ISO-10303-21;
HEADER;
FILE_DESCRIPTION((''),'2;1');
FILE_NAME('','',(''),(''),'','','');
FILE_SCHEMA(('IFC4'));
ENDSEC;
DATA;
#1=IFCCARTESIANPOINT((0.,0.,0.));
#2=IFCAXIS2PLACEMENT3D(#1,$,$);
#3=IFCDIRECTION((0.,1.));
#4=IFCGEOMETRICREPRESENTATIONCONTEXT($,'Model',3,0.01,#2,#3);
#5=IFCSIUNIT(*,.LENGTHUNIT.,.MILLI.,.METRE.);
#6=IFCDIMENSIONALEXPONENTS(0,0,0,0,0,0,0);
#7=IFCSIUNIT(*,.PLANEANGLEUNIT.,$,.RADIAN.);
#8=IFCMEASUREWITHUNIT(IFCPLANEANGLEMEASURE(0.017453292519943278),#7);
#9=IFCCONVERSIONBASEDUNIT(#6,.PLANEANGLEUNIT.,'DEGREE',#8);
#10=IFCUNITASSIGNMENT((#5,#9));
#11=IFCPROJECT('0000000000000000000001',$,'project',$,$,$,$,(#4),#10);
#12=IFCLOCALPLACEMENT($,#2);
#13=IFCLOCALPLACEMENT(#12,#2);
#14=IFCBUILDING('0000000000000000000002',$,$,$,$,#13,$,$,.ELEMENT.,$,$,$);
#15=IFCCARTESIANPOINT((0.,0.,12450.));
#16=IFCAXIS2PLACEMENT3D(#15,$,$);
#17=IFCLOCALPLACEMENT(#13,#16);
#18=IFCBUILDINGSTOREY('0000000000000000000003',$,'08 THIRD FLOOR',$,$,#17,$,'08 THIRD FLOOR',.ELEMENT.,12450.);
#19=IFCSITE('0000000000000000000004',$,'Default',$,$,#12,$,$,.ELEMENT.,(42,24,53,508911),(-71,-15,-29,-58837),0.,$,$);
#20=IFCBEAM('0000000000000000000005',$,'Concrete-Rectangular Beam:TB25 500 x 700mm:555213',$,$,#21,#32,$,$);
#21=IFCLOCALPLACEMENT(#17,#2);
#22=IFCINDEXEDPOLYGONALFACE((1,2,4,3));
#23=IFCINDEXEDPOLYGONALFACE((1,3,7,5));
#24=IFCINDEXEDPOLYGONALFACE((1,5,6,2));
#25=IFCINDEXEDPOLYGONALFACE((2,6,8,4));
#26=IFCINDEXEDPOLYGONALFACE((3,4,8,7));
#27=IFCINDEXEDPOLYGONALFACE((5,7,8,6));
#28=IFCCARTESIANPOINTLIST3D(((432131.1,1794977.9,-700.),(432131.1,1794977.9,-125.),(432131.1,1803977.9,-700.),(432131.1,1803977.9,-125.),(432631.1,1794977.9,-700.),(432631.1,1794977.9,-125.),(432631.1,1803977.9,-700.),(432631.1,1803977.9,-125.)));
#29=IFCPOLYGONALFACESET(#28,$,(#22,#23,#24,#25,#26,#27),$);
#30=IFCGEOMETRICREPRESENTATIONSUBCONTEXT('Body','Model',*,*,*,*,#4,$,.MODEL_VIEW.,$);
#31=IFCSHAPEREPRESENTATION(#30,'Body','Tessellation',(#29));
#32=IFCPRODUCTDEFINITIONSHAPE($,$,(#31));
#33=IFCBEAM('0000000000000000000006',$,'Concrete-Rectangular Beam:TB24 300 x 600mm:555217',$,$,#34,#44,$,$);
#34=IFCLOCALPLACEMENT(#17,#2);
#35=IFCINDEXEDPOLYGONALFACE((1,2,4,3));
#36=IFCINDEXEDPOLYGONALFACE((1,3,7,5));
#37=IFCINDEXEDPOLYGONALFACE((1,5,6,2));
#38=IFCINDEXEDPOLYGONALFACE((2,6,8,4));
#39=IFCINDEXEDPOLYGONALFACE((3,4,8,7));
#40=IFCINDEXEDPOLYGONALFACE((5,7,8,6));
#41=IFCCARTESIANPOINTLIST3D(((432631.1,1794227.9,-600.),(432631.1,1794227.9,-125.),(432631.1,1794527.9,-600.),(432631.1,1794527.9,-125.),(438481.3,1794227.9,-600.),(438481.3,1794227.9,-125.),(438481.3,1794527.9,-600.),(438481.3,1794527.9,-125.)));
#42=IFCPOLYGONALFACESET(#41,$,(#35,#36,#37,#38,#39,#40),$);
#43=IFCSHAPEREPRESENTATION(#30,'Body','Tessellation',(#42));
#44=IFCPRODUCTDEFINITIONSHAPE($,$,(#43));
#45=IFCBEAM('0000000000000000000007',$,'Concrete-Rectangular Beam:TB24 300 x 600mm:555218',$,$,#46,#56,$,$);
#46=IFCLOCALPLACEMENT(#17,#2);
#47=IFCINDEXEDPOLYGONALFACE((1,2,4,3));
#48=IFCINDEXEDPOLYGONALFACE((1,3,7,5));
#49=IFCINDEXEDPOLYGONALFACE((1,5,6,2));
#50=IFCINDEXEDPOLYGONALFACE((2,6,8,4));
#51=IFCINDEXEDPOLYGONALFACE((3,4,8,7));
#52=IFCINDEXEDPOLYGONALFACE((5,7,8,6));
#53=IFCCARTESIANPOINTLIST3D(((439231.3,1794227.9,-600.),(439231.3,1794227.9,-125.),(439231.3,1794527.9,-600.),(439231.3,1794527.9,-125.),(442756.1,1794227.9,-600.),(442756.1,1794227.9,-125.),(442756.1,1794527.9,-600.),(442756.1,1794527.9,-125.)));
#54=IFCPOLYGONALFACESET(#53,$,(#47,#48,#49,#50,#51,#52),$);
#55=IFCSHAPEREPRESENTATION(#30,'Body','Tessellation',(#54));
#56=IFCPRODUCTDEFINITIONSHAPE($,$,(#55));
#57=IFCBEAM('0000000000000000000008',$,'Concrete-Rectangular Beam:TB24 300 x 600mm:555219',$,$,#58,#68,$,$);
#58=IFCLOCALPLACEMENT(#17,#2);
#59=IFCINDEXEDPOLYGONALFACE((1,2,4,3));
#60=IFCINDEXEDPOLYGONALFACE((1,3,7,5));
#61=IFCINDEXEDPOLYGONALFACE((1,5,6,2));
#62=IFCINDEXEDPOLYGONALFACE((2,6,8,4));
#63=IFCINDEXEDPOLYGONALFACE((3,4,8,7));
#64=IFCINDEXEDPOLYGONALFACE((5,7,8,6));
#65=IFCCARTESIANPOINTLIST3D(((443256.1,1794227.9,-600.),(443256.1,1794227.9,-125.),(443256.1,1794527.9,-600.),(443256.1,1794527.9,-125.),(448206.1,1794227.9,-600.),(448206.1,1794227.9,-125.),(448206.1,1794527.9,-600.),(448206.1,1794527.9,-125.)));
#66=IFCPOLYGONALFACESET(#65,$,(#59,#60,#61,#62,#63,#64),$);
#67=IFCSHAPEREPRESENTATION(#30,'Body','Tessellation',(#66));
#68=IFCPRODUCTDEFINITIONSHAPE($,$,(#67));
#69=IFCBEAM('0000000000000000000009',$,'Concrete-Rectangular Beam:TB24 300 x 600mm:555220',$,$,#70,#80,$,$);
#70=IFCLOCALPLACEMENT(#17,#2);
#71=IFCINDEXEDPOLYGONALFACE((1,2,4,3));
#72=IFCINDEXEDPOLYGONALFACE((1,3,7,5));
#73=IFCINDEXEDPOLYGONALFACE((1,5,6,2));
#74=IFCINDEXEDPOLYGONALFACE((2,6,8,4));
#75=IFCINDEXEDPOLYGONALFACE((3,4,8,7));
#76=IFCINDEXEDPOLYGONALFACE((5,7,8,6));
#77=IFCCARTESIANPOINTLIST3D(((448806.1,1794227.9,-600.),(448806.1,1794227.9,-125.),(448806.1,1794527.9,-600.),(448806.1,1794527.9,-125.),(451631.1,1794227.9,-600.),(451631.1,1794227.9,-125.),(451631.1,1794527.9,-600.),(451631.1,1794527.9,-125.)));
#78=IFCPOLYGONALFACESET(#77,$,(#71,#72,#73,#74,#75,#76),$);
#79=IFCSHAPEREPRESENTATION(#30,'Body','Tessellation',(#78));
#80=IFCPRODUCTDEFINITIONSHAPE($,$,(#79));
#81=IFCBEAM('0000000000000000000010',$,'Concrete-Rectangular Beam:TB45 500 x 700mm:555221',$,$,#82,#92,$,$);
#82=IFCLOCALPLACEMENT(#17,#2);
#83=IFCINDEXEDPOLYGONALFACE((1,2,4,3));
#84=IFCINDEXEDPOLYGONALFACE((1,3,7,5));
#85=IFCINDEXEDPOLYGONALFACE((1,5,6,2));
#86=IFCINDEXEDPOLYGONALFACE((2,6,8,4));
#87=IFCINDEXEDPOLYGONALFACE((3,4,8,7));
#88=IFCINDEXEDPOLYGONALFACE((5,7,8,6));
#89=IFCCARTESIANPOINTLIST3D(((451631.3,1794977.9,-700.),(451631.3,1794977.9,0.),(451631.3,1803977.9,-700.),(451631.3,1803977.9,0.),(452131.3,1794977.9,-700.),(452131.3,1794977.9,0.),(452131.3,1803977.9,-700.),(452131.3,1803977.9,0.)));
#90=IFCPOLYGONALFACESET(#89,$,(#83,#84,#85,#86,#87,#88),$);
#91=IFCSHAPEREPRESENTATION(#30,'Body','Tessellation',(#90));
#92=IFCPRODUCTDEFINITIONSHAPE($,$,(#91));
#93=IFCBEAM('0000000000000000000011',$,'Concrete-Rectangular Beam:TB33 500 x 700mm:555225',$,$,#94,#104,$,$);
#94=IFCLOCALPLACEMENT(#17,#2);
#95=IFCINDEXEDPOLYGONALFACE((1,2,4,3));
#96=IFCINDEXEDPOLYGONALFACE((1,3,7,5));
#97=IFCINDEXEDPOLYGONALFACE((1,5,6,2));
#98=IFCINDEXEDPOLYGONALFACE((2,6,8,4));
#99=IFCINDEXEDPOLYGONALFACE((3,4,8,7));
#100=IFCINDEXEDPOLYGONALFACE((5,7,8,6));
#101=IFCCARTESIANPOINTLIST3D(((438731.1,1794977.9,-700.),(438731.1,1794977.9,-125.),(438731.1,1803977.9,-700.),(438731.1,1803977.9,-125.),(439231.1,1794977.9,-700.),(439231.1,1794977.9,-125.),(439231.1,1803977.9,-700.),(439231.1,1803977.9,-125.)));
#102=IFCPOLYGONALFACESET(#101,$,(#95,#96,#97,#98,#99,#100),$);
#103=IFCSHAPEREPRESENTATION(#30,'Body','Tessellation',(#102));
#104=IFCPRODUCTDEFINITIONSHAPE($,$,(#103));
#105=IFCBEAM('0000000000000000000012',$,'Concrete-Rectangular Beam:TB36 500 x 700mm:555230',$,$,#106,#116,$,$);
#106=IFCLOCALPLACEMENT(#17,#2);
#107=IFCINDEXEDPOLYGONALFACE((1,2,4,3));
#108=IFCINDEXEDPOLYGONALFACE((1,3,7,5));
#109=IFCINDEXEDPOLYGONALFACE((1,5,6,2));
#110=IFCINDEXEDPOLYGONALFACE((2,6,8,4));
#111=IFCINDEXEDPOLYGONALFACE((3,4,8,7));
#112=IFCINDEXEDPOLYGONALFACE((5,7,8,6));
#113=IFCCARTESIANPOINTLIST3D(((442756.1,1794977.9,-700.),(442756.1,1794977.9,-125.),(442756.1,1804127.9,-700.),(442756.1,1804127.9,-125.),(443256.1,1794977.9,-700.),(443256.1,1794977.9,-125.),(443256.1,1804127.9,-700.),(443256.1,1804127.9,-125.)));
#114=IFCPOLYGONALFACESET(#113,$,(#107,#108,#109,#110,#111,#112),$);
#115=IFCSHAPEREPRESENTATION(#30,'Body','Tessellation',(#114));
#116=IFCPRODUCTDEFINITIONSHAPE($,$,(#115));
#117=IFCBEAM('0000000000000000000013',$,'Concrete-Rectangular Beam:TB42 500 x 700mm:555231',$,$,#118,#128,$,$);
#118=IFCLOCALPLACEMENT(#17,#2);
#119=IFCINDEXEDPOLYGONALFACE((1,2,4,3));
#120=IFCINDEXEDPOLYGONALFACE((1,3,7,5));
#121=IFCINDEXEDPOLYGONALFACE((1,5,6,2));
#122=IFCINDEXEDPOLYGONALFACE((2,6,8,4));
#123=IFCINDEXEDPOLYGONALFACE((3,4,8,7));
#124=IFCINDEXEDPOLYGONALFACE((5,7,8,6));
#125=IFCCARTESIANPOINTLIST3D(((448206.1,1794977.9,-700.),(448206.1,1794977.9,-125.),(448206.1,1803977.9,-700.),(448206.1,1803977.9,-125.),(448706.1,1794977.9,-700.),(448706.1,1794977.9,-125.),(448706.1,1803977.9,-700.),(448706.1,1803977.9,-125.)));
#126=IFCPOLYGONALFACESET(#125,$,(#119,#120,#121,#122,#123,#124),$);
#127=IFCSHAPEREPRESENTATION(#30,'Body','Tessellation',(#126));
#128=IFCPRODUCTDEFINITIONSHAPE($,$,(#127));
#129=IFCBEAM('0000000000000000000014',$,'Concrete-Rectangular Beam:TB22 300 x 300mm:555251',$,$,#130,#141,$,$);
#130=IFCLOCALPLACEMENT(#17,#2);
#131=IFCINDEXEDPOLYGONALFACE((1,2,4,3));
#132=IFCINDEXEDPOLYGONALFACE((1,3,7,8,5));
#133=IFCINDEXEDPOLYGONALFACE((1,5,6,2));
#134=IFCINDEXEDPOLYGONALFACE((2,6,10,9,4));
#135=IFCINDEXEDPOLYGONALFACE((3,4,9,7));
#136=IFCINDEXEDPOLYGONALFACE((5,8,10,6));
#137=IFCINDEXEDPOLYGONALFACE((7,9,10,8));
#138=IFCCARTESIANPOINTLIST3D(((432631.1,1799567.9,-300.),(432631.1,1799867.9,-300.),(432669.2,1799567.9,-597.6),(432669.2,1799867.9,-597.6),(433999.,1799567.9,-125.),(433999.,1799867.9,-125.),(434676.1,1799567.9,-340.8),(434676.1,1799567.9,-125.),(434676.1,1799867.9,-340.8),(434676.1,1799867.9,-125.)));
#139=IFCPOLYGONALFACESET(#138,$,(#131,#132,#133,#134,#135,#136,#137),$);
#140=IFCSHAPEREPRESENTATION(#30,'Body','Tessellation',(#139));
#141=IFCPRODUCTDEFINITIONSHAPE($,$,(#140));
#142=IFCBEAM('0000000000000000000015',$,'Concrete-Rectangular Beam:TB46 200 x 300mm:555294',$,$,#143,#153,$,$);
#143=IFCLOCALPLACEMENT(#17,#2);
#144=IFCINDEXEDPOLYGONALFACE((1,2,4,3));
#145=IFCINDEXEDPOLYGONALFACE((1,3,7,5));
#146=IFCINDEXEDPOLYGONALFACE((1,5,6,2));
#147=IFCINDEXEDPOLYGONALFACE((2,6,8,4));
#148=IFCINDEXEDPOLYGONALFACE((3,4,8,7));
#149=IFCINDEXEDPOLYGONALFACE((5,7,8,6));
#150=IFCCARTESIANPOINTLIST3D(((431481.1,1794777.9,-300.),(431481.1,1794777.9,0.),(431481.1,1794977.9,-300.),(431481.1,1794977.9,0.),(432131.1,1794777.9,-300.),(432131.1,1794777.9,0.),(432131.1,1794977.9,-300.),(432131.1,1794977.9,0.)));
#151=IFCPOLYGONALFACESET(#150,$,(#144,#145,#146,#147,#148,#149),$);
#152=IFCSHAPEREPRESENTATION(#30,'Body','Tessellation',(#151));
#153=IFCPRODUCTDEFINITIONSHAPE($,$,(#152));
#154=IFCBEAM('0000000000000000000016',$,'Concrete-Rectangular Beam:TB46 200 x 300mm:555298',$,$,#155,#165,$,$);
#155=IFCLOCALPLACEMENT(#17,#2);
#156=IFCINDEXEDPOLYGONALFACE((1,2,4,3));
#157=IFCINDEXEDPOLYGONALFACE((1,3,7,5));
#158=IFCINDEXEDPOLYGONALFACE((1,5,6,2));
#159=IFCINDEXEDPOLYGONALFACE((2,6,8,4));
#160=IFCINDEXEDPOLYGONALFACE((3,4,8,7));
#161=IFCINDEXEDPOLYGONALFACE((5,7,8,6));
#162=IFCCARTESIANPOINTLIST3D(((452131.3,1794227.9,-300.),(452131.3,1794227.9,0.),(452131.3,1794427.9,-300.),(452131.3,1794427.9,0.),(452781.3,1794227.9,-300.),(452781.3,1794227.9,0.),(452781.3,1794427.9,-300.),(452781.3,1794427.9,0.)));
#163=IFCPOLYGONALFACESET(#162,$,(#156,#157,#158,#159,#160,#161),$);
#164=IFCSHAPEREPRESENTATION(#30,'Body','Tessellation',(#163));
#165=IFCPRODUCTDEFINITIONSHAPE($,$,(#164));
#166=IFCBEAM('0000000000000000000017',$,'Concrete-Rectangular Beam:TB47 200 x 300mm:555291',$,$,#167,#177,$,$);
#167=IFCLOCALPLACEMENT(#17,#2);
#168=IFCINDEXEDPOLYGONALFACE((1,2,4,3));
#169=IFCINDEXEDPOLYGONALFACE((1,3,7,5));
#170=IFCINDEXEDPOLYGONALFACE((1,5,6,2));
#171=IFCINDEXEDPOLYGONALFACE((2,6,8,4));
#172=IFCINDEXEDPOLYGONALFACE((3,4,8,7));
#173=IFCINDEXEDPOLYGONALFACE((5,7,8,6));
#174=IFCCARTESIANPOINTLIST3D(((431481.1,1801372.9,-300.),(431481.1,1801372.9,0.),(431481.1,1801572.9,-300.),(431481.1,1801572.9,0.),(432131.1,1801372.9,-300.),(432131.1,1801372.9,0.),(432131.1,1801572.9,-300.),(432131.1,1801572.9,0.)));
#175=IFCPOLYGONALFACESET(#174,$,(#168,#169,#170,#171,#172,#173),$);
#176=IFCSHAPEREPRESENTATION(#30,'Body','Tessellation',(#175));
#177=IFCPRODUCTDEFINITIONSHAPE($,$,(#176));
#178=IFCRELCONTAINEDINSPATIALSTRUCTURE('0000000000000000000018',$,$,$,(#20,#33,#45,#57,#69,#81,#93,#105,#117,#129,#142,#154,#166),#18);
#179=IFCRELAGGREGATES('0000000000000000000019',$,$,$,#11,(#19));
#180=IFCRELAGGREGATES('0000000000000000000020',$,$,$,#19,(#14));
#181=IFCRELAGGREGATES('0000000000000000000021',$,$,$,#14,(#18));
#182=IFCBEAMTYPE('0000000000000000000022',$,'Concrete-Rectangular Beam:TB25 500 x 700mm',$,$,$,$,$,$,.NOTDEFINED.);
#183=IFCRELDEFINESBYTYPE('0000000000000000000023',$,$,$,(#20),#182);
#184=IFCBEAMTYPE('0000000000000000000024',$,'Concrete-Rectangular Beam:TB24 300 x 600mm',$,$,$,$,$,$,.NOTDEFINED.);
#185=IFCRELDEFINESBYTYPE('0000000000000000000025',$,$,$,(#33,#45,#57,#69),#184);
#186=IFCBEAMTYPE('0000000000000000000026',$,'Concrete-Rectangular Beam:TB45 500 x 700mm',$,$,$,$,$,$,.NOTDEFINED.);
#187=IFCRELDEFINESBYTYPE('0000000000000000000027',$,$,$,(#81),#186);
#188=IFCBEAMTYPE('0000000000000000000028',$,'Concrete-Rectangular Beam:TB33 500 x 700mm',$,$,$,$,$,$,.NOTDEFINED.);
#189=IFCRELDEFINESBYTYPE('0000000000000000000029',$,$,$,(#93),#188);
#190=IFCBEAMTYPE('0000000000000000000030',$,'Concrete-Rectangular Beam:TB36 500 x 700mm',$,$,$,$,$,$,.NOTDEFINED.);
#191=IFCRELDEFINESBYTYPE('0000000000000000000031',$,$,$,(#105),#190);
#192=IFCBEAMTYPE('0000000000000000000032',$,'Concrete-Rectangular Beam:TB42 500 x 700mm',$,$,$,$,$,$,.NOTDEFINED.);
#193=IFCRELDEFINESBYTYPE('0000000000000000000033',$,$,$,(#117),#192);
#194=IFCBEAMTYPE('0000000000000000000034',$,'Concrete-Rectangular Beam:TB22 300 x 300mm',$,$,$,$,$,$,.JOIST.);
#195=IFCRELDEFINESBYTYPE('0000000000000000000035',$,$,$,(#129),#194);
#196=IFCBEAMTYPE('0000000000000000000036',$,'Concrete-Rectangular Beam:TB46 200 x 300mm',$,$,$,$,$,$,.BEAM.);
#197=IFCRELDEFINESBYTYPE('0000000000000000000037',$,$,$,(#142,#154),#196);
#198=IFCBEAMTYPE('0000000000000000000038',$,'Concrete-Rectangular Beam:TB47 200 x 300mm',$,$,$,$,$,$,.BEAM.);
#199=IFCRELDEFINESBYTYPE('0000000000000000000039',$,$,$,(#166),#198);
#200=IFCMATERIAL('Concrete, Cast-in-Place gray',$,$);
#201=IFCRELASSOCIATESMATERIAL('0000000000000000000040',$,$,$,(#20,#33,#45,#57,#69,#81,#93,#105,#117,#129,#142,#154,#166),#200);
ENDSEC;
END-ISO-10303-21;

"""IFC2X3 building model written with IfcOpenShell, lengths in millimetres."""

from ifc_helpers import new_model, entity, si_unit, converted_unit, direction, frame, frame_2d, origin, place, context, subcontext, project, spatial, rectangle, extrude, clip, halfspace, material, type_object, element, save


model = new_model("IFC2X3")

# Units and contexts
model_context = context("Model", 3, precision=0.01, world=origin(), true_north=direction((0.0, 1.0)))
body_context = subcontext(model_context, "Body", "Model", "MODEL_VIEW")
ifc_project = project(units=[si_unit("LENGTHUNIT", "METRE", prefix="MILLI"), converted_unit("PLANEANGLEUNIT", "DEGREE", entity("IfcPlaneAngleMeasure", 0.017453292519943278), si_unit("PLANEANGLEUNIT", "RADIAN"), dimensions=[0, 0, 0, 0, 0, 0, 0])], contexts=[model_context])

# Site, building, storey
site_placement = place(None, origin())
site = spatial("IfcSite", under=ifc_project, at=site_placement, Name="Default", CompositionType="ELEMENT", RefLatitude=(42, 24, 53, 508911), RefLongitude=(-71, -15, -29, -58837), RefElevation=0.0)
building_placement = place(site_placement, origin())
building = spatial("IfcBuilding", under=site, at=building_placement, CompositionType="ELEMENT")
storey_placement = place(building_placement, frame((0.0, 0.0, 12450.0)))
storey = spatial("IfcBuildingStorey", under=building, at=storey_placement, Name="08 THIRD FLOOR", LongName="08 THIRD FLOOR", CompositionType="ELEMENT", Elevation=12450.0)

# Shared definitions
ifc_material_1 = material(Name="Concrete, Cast-in-Place gray")

# Beams
beam_type_1 = type_object("IfcBeamType", Name="Concrete-Rectangular Beam:TB25 500 x 700mm", PredefinedType="NOTDEFINED")
beam_1_placement = place(storey_placement, frame((432631.1, 1794977.9, 0.0), z_axis=(0.0, 0.0, 1.0), x_axis=(0.0, 1.0, 0.0)))
element("IfcBeam", 1, at=beam_1_placement, inside=storey, type_object=beam_type_1, material=ifc_material_1, Name="Concrete-Rectangular Beam:TB25 500 x 700mm:555213", context=body_context, shape_type="SweptSolid", body=[
    extrude(rectangle(XDim=575.0, YDim=500.0, at=frame_2d((0.0, 0.0), x_axis=(1.0, 0.0))), frame((0.0, 250.0, -412.5), z_axis=(1.0, 0.0, 0.0), x_axis=(0.0, 0.0, -1.0)), (0.0, 0.0, 1.0), 9000.0),
])
beam_type_2 = type_object("IfcBeamType", Name="Concrete-Rectangular Beam:TB24 300 x 600mm", PredefinedType="NOTDEFINED")
beam_2_placement = place(storey_placement, frame((432631.1, 1794527.9, 0.0)))
element("IfcBeam", 2, at=beam_2_placement, inside=storey, type_object=beam_type_2, material=ifc_material_1, Name="Concrete-Rectangular Beam:TB24 300 x 600mm:555217", context=body_context, shape_type="SweptSolid", body=[
    extrude(rectangle(XDim=475.0, YDim=300.0, at=frame_2d((0.0, 0.0), x_axis=(1.0, 0.0))), frame((0.0, -150.0, -362.5), z_axis=(1.0, 0.0, 0.0), x_axis=(0.0, 0.0, -1.0)), (0.0, 0.0, 1.0), 5850.2),
])
beam_3_placement = place(storey_placement, frame((439231.1, 1794527.9, 0.0)))
element("IfcBeam", 3, at=beam_3_placement, inside=storey, type_object=beam_type_2, material=ifc_material_1, Name="Concrete-Rectangular Beam:TB24 300 x 600mm:555218", context=body_context, shape_type="SweptSolid", body=[
    extrude(rectangle(XDim=475.0, YDim=300.0, at=frame_2d((0.0, 0.0), x_axis=(1.0, 0.0))), frame((0.2, -150.0, -362.5), z_axis=(1.0, 0.0, 0.0), x_axis=(0.0, 0.0, -1.0)), (0.0, 0.0, 1.0), 3524.8),
])
beam_4_placement = place(storey_placement, frame((443256.1, 1794527.9, 0.0)))
element("IfcBeam", 4, at=beam_4_placement, inside=storey, type_object=beam_type_2, material=ifc_material_1, Name="Concrete-Rectangular Beam:TB24 300 x 600mm:555219", context=body_context, shape_type="SweptSolid", body=[
    extrude(rectangle(XDim=475.0, YDim=300.0, at=frame_2d((0.0, 0.0), x_axis=(1.0, 0.0))), frame((0.0, -150.0, -362.5), z_axis=(1.0, 0.0, 0.0), x_axis=(0.0, 0.0, -1.0)), (0.0, 0.0, 1.0), 4950.0),
])
beam_5_placement = place(storey_placement, frame((448806.1, 1794527.9, 0.0)))
element("IfcBeam", 5, at=beam_5_placement, inside=storey, type_object=beam_type_2, material=ifc_material_1, Name="Concrete-Rectangular Beam:TB24 300 x 600mm:555220", context=body_context, shape_type="SweptSolid", body=[
    extrude(rectangle(XDim=475.0, YDim=300.0, at=frame_2d((0.0, 0.0), x_axis=(1.0, 0.0))), frame((0.0, -150.0, -362.5), z_axis=(1.0, 0.0, 0.0), x_axis=(0.0, 0.0, -1.0)), (0.0, 0.0, 1.0), 2825.0),
])
beam_type_3 = type_object("IfcBeamType", Name="Concrete-Rectangular Beam:TB45 500 x 700mm", PredefinedType="NOTDEFINED")
beam_6_placement = place(storey_placement, frame((451631.3, 1794977.9, 0.0), z_axis=(0.0, 0.0, 1.0), x_axis=(0.0, 1.0, 0.0)))
element("IfcBeam", 6, at=beam_6_placement, inside=storey, type_object=beam_type_3, material=ifc_material_1, Name="Concrete-Rectangular Beam:TB45 500 x 700mm:555221", context=body_context, shape_type="SweptSolid", body=[
    extrude(rectangle(XDim=700.0, YDim=500.0, at=frame_2d((0.0, 0.0), x_axis=(1.0, 0.0))), frame((0.0, -250.0, -350.0), z_axis=(1.0, 0.0, 0.0), x_axis=(0.0, 0.0, -1.0)), (0.0, 0.0, 1.0), 9000.0),
])
beam_type_4 = type_object("IfcBeamType", Name="Concrete-Rectangular Beam:TB33 500 x 700mm", PredefinedType="NOTDEFINED")
beam_7_placement = place(storey_placement, frame((438731.1, 1794977.9, 0.0), z_axis=(0.0, 0.0, 1.0), x_axis=(0.0, 1.0, 0.0)))
element("IfcBeam", 7, at=beam_7_placement, inside=storey, type_object=beam_type_4, material=ifc_material_1, Name="Concrete-Rectangular Beam:TB33 500 x 700mm:555225", context=body_context, shape_type="SweptSolid", body=[
    extrude(rectangle(XDim=575.0, YDim=500.0, at=frame_2d((0.0, 0.0), x_axis=(1.0, 0.0))), frame((0.0, -250.0, -412.5), z_axis=(1.0, 0.0, 0.0), x_axis=(0.0, 0.0, -1.0)), (0.0, 0.0, 1.0), 9000.0),
])
beam_type_5 = type_object("IfcBeamType", Name="Concrete-Rectangular Beam:TB36 500 x 700mm", PredefinedType="NOTDEFINED")
beam_8_placement = place(storey_placement, frame((442756.1, 1794977.5, 0.0), z_axis=(0.0, 0.0, 1.0), x_axis=(0.0, 1.0, 0.0)))
element("IfcBeam", 8, at=beam_8_placement, inside=storey, type_object=beam_type_5, material=ifc_material_1, Name="Concrete-Rectangular Beam:TB36 500 x 700mm:555230", context=body_context, shape_type="SweptSolid", body=[
    extrude(rectangle(XDim=575.0, YDim=500.0, at=frame_2d((0.0, 0.0), x_axis=(1.0, 0.0))), frame((0.4, -250.0, -412.5), z_axis=(1.0, 0.0, 0.0), x_axis=(0.0, 0.0, -1.0)), (0.0, 0.0, 1.0), 9150.0),
])
beam_type_6 = type_object("IfcBeamType", Name="Concrete-Rectangular Beam:TB42 500 x 700mm", PredefinedType="NOTDEFINED")
beam_9_placement = place(storey_placement, frame((448206.1, 1794977.9, 0.0), z_axis=(0.0, 0.0, 1.0), x_axis=(0.0, 1.0, 0.0)))
element("IfcBeam", 9, at=beam_9_placement, inside=storey, type_object=beam_type_6, material=ifc_material_1, Name="Concrete-Rectangular Beam:TB42 500 x 700mm:555231", context=body_context, shape_type="SweptSolid", body=[
    extrude(rectangle(XDim=575.0, YDim=500.0, at=frame_2d((0.0, 0.0), x_axis=(1.0, 0.0))), frame((0.0, -250.0, -412.5), z_axis=(1.0, 0.0, 0.0), x_axis=(0.0, 0.0, -1.0)), (0.0, 0.0, 1.0), 9000.0),
])
beam_type_7 = type_object("IfcBeamType", Name="Concrete-Rectangular Beam:TB22 300 x 300mm", PredefinedType="JOIST")
beam_10_placement = place(storey_placement, frame((432631.1, 1799867.9, -300.0), z_axis=(-0.126898, 0.0, 0.991916), x_axis=(0.991916, 0.0, 0.126898)))
element("IfcBeam", 10, at=beam_10_placement, inside=storey, type_object=beam_type_7, material=ifc_material_1, Name="Concrete-Rectangular Beam:TB22 300 x 300mm:555251", context=body_context, shape_type="Clipping", body=[
    clip(clip(extrude(rectangle(XDim=300.0, YDim=300.0, at=frame_2d((0.0, 0.0), x_axis=(0.0, 1.0))), frame((0.0, -150.0, -150.0), z_axis=(1.0, 0.0, 0.0), x_axis=(0.0, 1.0, 0.0)), (0.0, 0.0, 1.0), 2050.7), halfspace(frame((2066.5, -1302.3, 38.1), z_axis=(0.991916, 0.0, -0.126898), x_axis=(0.0, 1.0, 0.0)), False)), halfspace(frame((10809.3, 24360.0, -1206.4), z_axis=(0.126898, 0.0, 0.991916), x_axis=(0.0, -1.0, 0.0)), False)),
])
beam_type_8 = type_object("IfcBeamType", Name="Concrete-Rectangular Beam:TB46 200 x 300mm", PredefinedType="BEAM")
beam_11_placement = place(storey_placement, frame((431481.1, 1794777.9, 0.0)))
element("IfcBeam", 11, at=beam_11_placement, inside=storey, type_object=beam_type_8, material=ifc_material_1, Name="Concrete-Rectangular Beam:TB46 200 x 300mm:555294", context=body_context, shape_type="SweptSolid", body=[
    extrude(rectangle(XDim=300.0, YDim=200.0, at=frame_2d((0.0, 0.0), x_axis=(1.0, 0.0))), frame((0.0, 100.0, -150.0), z_axis=(1.0, 0.0, 0.0), x_axis=(0.0, 0.0, -1.0)), (0.0, 0.0, 1.0), 650.0),
])
beam_12_placement = place(storey_placement, frame((452781.3, 1794227.9, 0.0), z_axis=(0.0, 0.0, 1.0), x_axis=(-1.0, 0.0, 0.0)))
element("IfcBeam", 12, at=beam_12_placement, inside=storey, type_object=beam_type_8, material=ifc_material_1, Name="Concrete-Rectangular Beam:TB46 200 x 300mm:555298", context=body_context, shape_type="SweptSolid", body=[
    extrude(rectangle(XDim=300.0, YDim=200.0, at=frame_2d((0.0, 0.0), x_axis=(1.0, 0.0))), frame((0.0, -100.0, -150.0), z_axis=(1.0, 0.0, 0.0), x_axis=(0.0, 0.0, -1.0)), (0.0, 0.0, 1.0), 650.0),
])
beam_type_9 = type_object("IfcBeamType", Name="Concrete-Rectangular Beam:TB47 200 x 300mm", PredefinedType="BEAM")
beam_13_placement = place(storey_placement, frame((431681.1, 1801372.9, 0.0)))
element("IfcBeam", 13, at=beam_13_placement, inside=storey, type_object=beam_type_9, material=ifc_material_1, Name="Concrete-Rectangular Beam:TB47 200 x 300mm:555291", context=body_context, shape_type="SweptSolid", body=[
    extrude(rectangle(XDim=300.0, YDim=200.0, at=frame_2d((0.0, 0.0), x_axis=(1.0, 0.0))), frame((-200.0, 100.0, -150.0), z_axis=(1.0, 0.0, 0.0), x_axis=(0.0, 0.0, -1.0)), (0.0, 0.0, 1.0), 650.0),
])

save(model, "model.ifc")
